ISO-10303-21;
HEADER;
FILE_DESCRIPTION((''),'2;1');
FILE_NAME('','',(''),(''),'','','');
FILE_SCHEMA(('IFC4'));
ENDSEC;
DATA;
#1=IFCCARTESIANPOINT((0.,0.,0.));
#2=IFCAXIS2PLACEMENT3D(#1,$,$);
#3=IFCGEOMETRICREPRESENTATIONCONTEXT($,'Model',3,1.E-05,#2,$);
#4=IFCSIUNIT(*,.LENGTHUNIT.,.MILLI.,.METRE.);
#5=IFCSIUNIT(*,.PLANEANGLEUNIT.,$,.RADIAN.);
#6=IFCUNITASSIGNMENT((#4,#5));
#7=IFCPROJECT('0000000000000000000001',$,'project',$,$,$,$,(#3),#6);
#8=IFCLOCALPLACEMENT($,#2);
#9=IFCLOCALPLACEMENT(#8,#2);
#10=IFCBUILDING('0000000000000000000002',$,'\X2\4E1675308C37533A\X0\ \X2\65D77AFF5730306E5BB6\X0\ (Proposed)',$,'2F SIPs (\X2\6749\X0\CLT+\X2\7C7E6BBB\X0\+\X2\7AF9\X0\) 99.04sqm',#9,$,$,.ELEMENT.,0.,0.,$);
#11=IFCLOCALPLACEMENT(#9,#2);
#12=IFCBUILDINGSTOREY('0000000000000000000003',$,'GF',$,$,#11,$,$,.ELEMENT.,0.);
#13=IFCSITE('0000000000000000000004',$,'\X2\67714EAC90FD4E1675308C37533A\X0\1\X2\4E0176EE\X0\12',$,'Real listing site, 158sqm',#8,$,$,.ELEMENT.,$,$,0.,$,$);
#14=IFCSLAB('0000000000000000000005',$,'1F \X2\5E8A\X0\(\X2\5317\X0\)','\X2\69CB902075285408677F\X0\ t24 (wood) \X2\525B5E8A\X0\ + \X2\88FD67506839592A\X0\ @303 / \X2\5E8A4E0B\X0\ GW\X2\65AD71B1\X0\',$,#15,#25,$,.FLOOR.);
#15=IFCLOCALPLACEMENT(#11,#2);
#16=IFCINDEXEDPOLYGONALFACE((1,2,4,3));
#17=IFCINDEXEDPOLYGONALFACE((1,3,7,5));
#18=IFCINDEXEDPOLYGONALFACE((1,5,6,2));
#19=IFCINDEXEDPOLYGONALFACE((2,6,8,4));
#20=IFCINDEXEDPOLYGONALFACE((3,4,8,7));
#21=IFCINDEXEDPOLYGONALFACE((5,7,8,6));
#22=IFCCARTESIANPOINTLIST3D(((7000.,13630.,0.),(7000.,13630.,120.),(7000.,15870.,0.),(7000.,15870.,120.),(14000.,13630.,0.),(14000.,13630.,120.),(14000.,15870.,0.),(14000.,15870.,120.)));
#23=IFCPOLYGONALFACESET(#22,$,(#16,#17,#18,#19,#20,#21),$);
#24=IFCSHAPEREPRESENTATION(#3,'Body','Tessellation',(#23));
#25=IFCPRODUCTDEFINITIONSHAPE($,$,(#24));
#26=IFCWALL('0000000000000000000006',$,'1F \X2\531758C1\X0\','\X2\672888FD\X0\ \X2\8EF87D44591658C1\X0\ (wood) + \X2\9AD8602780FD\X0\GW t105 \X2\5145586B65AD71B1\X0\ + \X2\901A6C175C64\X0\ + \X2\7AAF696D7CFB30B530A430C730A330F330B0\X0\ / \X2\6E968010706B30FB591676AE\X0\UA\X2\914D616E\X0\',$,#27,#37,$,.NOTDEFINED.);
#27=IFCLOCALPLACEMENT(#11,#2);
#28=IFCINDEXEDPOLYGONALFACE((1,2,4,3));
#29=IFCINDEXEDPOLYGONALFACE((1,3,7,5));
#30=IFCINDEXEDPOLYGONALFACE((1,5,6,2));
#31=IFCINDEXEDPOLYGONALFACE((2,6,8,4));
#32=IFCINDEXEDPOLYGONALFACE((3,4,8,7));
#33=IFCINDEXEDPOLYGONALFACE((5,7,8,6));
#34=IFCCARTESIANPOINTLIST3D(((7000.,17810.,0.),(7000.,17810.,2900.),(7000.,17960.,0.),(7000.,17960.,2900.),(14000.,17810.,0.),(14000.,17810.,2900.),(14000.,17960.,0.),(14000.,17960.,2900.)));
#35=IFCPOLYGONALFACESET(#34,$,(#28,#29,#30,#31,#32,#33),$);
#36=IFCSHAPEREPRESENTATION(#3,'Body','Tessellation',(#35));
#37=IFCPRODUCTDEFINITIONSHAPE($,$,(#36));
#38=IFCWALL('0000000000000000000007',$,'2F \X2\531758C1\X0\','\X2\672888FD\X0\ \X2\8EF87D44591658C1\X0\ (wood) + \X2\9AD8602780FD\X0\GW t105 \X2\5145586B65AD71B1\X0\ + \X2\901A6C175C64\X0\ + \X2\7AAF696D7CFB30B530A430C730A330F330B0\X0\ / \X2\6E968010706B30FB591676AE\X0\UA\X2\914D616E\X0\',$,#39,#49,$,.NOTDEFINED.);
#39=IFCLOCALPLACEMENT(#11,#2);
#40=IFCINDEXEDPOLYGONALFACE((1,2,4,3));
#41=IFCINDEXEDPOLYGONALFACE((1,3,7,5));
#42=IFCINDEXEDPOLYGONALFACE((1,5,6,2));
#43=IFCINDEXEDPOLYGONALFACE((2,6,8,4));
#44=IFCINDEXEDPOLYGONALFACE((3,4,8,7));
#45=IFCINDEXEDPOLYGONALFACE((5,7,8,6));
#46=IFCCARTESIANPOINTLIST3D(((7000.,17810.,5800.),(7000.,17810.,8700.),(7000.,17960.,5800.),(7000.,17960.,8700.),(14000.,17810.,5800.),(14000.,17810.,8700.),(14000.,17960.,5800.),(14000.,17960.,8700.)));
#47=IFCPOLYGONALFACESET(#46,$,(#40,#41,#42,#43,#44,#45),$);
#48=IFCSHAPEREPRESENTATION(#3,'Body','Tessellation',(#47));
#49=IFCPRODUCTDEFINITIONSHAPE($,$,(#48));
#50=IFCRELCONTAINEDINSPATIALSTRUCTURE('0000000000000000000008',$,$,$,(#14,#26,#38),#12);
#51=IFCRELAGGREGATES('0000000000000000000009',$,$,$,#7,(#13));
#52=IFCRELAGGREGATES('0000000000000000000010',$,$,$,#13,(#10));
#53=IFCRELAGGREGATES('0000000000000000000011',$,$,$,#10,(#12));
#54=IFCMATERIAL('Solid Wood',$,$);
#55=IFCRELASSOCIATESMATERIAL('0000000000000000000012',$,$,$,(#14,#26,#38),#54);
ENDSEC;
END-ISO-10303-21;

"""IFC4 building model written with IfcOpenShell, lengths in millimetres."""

from ifc_helpers import new_model, si_unit, frame, frame_2d, origin, place, context, project, spatial, rectangle, extrude, material, element, save


model = new_model("IFC4")

# Units and contexts
model_context = context("Model", 3, precision=1e-05, world=origin())
ifc_project = project(units=[si_unit("LENGTHUNIT", "METRE", prefix="MILLI"), si_unit("PLANEANGLEUNIT", "RADIAN")], contexts=[model_context])

# Site, building, storey
site_placement = place(None, origin())
site = spatial("IfcSite", under=ifc_project, at=site_placement, Name="東京都世田谷区1丁目12", ObjectType="Real listing site, 158sqm", CompositionType="ELEMENT", RefElevation=0.0)
building_placement = place(site_placement, origin())
building = spatial("IfcBuilding", under=site, at=building_placement, Name="世田谷区 旗竿地の家 (Proposed)", ObjectType="2F SIPs (杉CLT+籾殻+竹) 99.04sqm", CompositionType="ELEMENT", ElevationOfRefHeight=0.0, ElevationOfTerrain=0.0)
storey_placement = place(building_placement, origin())
storey = spatial("IfcBuildingStorey", under=building, at=storey_placement, Name="GF", CompositionType="ELEMENT", Elevation=0.0)

# Slab
ifc_material_1 = material(Name="Solid Wood")
slab_1_placement = place(storey_placement, frame((3500.0, 6815.0, 0.0)))
element("IfcSlab", 1, at=slab_1_placement, inside=storey, material=ifc_material_1, Name="1F 床(北)", Description="構造用合板 t24 (wood) 剛床 + 製材根太 @303 / 床下 GW断熱", PredefinedType="FLOOR", context=model_context, shape_type="SweptSolid", body=[
    extrude(rectangle(XDim=7000.0, YDim=2240.0, at=frame_2d((3500.0, 1120.0))), frame((3500.0, 6815.0, 0.0)), (0.0, 0.0, 1.0), 120.0),
])

# Wall
wall_1_placement = place(storey_placement, frame((3500.0, 8905.0, 0.0)))
element("IfcWall", 2, at=wall_1_placement, inside=storey, material=ifc_material_1, Name="1F 北壁", Description="木製 軸組外壁 (wood) + 高性能GW t105 充填断熱 + 通気層 + 窯業系サイディング / 準耐火・外皮UA配慮", PredefinedType="NOTDEFINED", context=model_context, shape_type="SweptSolid", body=[
    extrude(rectangle(XDim=7000.0, YDim=150.0, at=frame_2d((3500.0, 75.0))), frame((3500.0, 8905.0, 0.0)), (0.0, 0.0, 1.0), 2900.0),
])

# Wall
wall_2_placement = place(storey_placement, frame((3500.0, 8905.0, 2900.0)))
element("IfcWall", 3, at=wall_2_placement, inside=storey, material=ifc_material_1, Name="2F 北壁", Description="木製 軸組外壁 (wood) + 高性能GW t105 充填断熱 + 通気層 + 窯業系サイディング / 準耐火・外皮UA配慮", PredefinedType="NOTDEFINED", context=model_context, shape_type="SweptSolid", body=[
    extrude(rectangle(XDim=7000.0, YDim=150.0, at=frame_2d((3500.0, 75.0))), frame((3500.0, 8905.0, 2900.0)), (0.0, 0.0, 1.0), 2900.0),
])

save(model, "model.ifc")
